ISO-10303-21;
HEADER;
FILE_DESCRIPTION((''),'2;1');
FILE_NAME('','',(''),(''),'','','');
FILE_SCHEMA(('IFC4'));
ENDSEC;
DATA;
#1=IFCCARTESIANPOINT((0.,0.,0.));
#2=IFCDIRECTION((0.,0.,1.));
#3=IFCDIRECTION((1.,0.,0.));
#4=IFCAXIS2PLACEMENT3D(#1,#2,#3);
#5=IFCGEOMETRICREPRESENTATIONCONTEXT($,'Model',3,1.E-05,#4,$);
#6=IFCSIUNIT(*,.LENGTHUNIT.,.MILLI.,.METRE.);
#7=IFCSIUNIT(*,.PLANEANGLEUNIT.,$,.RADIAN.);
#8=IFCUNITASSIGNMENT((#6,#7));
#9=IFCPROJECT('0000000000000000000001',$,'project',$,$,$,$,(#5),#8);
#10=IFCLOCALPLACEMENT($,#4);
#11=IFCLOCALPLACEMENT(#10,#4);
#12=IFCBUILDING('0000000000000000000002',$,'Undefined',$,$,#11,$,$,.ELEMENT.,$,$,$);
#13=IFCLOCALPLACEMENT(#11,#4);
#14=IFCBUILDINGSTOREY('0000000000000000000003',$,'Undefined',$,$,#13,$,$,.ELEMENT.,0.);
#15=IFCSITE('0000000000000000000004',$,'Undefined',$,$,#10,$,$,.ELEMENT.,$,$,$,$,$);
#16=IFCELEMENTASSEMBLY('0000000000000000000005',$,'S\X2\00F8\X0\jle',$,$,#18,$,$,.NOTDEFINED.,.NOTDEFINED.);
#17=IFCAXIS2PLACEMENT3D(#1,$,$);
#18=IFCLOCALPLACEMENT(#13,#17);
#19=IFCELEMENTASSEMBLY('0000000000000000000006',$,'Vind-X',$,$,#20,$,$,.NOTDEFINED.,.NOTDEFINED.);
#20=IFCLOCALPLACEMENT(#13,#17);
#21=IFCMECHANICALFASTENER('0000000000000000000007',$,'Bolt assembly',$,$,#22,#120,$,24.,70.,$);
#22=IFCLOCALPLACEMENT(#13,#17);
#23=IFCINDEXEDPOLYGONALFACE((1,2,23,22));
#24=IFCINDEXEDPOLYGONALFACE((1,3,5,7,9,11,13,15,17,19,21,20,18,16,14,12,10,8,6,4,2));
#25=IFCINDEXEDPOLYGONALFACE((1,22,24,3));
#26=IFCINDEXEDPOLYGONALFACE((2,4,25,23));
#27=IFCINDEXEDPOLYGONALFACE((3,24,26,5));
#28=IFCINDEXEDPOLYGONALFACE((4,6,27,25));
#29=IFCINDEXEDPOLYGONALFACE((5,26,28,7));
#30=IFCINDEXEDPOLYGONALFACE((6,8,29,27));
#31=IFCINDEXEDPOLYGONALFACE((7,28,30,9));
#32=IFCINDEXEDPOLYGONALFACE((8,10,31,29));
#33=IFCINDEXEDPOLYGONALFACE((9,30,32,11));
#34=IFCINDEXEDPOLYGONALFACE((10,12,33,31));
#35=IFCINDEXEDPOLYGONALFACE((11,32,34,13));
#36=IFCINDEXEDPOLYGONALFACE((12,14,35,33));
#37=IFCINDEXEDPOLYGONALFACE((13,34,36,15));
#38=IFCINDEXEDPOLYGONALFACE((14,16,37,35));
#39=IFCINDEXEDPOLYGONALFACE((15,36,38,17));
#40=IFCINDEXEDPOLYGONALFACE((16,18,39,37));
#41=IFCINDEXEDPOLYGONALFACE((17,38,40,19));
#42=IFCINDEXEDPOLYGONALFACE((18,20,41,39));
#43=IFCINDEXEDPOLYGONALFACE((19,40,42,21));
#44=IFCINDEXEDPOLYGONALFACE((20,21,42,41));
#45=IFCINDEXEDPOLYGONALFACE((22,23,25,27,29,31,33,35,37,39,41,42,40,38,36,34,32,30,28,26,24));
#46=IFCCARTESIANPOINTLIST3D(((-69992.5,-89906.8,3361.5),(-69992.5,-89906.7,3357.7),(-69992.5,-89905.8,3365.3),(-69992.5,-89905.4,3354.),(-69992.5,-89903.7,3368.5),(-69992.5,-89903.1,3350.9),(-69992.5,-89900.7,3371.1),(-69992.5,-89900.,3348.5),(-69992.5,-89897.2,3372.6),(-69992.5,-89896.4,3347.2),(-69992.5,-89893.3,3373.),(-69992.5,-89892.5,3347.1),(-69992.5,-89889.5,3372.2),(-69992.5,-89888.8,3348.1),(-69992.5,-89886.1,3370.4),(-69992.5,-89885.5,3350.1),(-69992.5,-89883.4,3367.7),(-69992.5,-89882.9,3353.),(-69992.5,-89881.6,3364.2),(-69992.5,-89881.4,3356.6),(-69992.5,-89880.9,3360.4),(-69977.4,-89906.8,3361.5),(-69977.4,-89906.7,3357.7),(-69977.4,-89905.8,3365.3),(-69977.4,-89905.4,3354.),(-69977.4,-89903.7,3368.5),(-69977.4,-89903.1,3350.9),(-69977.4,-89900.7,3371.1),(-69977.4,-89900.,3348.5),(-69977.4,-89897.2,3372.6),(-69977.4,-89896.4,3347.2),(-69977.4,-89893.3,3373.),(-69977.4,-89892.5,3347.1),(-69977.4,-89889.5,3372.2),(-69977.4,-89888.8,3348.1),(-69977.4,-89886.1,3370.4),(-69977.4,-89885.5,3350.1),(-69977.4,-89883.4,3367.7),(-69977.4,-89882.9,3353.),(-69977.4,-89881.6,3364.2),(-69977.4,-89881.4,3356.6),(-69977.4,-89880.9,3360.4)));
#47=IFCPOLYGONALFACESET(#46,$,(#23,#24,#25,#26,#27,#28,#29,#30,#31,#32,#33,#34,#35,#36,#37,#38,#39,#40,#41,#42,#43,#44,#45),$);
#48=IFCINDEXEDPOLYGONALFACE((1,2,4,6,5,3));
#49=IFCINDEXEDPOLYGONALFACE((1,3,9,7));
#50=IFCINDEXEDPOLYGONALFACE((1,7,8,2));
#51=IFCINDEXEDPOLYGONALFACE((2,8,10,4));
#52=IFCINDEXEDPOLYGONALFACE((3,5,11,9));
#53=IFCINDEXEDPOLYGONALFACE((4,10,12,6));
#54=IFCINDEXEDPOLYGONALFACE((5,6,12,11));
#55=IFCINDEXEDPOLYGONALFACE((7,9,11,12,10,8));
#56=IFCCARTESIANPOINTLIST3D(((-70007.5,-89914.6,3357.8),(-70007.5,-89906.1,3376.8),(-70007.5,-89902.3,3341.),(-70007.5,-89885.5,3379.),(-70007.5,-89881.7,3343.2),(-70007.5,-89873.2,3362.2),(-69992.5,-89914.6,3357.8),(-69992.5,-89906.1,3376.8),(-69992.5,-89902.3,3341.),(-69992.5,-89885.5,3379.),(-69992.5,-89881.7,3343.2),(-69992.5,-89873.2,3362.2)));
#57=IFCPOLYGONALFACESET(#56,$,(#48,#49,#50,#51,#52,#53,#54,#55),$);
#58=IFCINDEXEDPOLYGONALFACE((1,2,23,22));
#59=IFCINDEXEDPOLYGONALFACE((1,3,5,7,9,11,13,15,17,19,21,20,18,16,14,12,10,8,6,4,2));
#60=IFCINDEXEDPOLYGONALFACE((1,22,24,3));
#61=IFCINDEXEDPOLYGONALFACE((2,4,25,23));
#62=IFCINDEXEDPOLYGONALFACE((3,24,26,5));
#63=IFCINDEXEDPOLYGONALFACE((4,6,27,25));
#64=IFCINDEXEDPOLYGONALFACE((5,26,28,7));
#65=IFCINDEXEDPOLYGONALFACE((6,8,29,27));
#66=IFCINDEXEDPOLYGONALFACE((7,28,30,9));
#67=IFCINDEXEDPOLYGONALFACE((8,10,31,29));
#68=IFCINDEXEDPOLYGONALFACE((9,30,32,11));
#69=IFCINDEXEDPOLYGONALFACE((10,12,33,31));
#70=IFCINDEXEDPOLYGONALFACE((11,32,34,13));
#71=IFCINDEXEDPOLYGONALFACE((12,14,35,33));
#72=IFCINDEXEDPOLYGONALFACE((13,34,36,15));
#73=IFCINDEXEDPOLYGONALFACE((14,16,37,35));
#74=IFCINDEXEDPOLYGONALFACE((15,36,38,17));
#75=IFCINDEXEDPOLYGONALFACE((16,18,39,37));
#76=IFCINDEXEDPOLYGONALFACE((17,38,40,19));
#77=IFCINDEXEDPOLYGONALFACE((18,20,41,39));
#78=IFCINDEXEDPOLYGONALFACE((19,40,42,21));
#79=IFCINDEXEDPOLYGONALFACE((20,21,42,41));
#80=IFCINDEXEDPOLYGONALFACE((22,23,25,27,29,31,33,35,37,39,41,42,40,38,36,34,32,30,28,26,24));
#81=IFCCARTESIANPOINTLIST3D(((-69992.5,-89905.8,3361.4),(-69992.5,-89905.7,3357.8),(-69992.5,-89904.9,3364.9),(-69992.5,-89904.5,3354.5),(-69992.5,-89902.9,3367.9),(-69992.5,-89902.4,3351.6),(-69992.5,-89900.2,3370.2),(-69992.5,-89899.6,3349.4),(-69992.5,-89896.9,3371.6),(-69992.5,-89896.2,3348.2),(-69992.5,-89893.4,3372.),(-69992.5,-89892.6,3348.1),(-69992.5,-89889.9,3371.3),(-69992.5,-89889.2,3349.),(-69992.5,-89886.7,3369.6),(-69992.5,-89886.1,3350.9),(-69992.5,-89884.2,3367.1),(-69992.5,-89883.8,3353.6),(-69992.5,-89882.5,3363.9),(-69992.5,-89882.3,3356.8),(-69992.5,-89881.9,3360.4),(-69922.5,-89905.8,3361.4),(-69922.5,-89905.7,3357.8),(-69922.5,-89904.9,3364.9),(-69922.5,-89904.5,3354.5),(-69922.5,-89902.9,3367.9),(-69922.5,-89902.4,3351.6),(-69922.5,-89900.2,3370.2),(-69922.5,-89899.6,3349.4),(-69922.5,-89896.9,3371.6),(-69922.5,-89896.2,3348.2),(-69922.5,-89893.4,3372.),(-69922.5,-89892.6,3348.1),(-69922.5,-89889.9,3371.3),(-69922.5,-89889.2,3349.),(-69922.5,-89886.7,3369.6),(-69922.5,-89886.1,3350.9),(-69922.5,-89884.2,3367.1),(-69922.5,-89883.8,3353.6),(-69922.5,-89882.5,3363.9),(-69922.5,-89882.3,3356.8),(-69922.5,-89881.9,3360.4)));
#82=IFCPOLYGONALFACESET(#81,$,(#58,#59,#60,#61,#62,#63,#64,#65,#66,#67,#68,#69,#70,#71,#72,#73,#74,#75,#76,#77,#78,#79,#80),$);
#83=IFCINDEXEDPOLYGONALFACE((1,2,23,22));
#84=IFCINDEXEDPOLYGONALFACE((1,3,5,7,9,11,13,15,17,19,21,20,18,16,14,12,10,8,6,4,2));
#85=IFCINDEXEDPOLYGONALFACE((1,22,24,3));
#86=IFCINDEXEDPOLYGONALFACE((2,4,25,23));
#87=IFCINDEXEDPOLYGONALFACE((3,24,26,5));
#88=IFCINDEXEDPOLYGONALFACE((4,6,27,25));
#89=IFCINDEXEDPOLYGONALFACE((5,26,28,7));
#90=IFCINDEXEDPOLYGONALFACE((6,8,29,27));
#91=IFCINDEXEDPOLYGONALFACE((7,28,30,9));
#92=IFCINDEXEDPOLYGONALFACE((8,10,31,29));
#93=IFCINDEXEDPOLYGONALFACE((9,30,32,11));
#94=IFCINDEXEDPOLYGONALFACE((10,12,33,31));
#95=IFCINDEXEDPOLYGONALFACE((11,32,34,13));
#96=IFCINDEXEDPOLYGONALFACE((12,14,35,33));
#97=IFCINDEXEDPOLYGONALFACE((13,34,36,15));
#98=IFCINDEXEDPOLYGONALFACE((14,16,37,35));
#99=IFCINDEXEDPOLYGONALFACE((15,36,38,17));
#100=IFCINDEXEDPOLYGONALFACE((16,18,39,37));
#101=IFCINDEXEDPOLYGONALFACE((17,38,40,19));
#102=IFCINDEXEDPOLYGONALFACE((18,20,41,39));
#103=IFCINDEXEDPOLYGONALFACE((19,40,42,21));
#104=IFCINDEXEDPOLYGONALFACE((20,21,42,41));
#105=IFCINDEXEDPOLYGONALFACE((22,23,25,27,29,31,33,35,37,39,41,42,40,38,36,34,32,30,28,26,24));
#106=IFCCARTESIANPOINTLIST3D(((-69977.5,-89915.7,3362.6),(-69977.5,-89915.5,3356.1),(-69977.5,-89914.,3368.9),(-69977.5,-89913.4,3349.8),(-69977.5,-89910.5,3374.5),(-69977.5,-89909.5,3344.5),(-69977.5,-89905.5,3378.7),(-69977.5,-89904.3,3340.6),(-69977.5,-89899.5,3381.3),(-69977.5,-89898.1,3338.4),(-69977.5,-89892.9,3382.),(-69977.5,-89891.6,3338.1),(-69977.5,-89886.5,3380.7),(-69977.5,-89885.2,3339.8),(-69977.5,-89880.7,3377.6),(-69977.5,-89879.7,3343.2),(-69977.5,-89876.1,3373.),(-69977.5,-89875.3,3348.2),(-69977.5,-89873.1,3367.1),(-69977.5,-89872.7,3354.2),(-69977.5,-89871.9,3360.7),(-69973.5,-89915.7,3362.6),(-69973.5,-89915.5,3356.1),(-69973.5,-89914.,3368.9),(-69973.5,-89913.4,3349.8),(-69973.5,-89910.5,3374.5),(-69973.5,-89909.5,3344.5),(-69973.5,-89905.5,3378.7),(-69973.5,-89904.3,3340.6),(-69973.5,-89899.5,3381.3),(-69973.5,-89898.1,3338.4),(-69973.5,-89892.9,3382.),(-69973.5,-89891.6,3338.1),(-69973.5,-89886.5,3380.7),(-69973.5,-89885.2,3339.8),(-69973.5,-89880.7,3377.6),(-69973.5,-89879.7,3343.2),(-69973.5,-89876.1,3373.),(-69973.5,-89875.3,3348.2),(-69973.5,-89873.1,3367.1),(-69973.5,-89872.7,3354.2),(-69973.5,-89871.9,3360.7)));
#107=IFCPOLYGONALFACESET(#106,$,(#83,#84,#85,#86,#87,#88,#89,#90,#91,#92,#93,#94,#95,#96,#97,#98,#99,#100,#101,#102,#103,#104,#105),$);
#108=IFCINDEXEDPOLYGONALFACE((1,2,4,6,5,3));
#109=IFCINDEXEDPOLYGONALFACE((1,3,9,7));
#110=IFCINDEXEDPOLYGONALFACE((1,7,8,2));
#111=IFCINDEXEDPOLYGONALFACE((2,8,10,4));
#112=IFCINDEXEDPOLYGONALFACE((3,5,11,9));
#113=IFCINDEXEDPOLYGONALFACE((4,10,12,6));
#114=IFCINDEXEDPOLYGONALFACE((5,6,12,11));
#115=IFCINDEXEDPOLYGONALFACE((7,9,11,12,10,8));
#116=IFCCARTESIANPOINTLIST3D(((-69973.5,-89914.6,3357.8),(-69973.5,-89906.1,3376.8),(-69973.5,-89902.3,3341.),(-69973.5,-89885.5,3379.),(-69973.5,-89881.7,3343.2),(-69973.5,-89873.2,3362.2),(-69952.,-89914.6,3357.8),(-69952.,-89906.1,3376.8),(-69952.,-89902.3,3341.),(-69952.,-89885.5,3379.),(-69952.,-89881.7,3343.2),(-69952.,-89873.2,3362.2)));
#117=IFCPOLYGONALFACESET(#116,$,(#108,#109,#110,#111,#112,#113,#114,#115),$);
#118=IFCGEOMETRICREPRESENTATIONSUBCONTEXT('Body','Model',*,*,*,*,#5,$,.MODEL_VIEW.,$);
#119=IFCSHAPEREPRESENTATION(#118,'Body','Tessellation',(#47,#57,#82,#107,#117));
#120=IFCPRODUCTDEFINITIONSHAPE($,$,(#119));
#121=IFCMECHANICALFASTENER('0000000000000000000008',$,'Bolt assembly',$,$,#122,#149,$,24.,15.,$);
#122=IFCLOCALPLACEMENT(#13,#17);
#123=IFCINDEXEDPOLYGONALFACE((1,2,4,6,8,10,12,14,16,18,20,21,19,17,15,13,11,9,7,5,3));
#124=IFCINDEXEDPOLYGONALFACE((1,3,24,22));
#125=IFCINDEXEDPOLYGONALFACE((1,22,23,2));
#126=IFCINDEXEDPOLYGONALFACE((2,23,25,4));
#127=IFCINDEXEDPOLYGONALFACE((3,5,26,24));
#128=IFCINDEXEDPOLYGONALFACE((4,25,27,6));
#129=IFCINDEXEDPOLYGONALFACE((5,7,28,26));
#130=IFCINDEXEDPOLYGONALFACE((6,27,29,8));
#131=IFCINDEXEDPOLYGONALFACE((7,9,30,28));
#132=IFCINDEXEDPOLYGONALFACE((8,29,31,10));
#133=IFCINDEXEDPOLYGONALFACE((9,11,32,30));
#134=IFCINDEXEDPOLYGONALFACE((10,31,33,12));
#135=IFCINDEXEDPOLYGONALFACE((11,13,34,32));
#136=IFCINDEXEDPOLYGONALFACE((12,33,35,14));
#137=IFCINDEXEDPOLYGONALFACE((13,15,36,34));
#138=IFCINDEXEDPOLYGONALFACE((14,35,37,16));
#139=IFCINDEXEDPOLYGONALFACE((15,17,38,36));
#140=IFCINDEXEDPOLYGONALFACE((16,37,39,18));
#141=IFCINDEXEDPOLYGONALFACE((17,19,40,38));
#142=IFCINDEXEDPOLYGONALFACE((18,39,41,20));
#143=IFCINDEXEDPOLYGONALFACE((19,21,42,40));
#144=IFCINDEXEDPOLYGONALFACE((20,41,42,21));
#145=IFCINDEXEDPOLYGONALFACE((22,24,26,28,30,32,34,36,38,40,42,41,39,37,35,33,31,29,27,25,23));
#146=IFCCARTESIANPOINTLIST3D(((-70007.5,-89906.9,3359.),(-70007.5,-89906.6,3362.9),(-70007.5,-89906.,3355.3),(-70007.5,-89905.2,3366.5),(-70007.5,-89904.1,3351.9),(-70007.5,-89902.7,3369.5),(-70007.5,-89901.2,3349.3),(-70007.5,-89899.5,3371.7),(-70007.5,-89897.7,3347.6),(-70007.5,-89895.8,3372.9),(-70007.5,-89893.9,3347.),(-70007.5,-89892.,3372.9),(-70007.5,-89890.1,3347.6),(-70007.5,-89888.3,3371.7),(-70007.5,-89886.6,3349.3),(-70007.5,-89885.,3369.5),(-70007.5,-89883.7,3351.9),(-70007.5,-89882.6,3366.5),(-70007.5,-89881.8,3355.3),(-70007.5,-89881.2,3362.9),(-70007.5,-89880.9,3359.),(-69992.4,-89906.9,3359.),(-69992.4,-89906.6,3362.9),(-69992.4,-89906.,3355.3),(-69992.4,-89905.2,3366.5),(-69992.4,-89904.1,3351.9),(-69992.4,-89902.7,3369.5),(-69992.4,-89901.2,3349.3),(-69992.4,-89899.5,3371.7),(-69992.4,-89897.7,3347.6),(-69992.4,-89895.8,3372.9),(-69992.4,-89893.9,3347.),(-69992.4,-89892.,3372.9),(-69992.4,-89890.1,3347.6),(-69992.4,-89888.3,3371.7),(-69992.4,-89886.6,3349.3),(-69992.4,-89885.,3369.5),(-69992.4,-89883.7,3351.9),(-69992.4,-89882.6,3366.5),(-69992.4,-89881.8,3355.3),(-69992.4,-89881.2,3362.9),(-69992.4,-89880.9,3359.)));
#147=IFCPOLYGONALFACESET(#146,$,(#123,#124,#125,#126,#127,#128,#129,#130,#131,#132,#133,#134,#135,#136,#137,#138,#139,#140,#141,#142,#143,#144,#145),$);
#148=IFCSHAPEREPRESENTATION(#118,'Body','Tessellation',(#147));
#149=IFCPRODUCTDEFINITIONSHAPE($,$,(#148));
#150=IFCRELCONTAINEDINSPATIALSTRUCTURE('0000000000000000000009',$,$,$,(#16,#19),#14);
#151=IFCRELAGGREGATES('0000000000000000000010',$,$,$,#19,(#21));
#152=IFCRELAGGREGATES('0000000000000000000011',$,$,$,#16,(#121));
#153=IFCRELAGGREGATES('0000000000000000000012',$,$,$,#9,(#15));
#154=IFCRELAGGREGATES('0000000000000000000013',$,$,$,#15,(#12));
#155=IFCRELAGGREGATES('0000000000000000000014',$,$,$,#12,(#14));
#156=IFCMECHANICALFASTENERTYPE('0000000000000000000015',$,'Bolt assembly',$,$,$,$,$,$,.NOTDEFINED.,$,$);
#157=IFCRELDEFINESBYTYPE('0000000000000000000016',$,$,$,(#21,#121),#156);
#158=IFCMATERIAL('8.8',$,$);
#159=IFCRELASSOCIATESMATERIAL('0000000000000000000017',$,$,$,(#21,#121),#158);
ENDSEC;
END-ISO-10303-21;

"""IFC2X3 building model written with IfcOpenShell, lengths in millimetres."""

from ifc_helpers import new_model, si_unit, frame, origin_with_axes, origin_2d_with_axis, place, context, subcontext, project, spatial, polyline, circle, outline, extrude, source, transform, mapped, material, type_object, element, aggregate, save


model = new_model("IFC2X3")

# Units and contexts
model_context = context("Model", 3, precision=1e-05, world=origin_with_axes())
body_context = subcontext(model_context, "Body", "Model", "MODEL_VIEW")
ifc_project = project(units=[si_unit("LENGTHUNIT", "METRE", prefix="MILLI"), si_unit("PLANEANGLEUNIT", "RADIAN")], contexts=[model_context])

# Site, building, storey
site_placement = place(None, origin_with_axes())
site = spatial("IfcSite", under=ifc_project, at=site_placement, Name="Undefined", CompositionType="ELEMENT")
building_placement = place(site_placement, origin_with_axes())
building = spatial("IfcBuilding", under=site, at=building_placement, Name="Undefined", CompositionType="ELEMENT")
storey_placement = place(building_placement, origin_with_axes())
storey = spatial("IfcBuildingStorey", under=building, at=storey_placement, Name="Undefined", CompositionType="ELEMENT", Elevation=0.0)

# Element assembly
assembly_1_placement = place(storey_placement, origin_with_axes())
assembly_1 = element("IfcElementAssembly", 1, at=assembly_1_placement, inside=storey, Name="Søjle", AssemblyPlace="NOTDEFINED", PredefinedType="NOTDEFINED")

# Element assembly
assembly_2_placement = place(storey_placement, origin_with_axes())
assembly_2 = element("IfcElementAssembly", 2, at=assembly_2_placement, inside=storey, Name="Vind-X", AssemblyPlace="NOTDEFINED", PredefinedType="NOTDEFINED")

# Mechanical fasteners
ifc_material_1 = material(Name="8.8")
mechanical_fastener_type = type_object("IfcMechanicalFastenerType", Name="Bolt assembly")
shared_shape_1 = source(origin_with_axes(), body_context, "Body", "SweptSolid", [
    extrude(circle(Radius=13.0, at=origin_2d_with_axis()), frame((0.0, 0.0, 0.0), z_axis=(0.0, 1.0, 0.0), x_axis=(1.0, 0.0, 0.0)), (0.0, 0.0, 1.0), 15.1),
    extrude(outline(polyline([(18.0, -10.4), (18.0, 10.4), (0.0, 20.8), (-18.0, 10.4), (-18.0, -10.4), (0.0, -20.8), (18.0, -10.4)])), frame((0.0, -15.0, 0.0), z_axis=(0.0, 1.0, 0.0), x_axis=(1.0, 0.0, 0.0)), (0.0, 0.0, 1.0), 15.0),
    extrude(circle(Radius=12.0, at=origin_2d_with_axis()), frame((0.0, 0.0, 0.0), z_axis=(0.0, 1.0, 0.0), x_axis=(1.0, 0.0, 0.0)), (0.0, 0.0, 1.0), 70.0),
    extrude(circle(Radius=22.0, at=origin_2d_with_axis()), frame((0.0, 15.0, 0.0), z_axis=(0.0, 1.0, 0.0), x_axis=(1.0, 0.0, 0.0)), (0.0, 0.0, 1.0), 4.0),
    extrude(outline(polyline([(18.0, -10.4), (18.0, 10.4), (0.0, 20.8), (-18.0, 10.4), (-18.0, -10.4), (0.0, -20.8), (18.0, -10.4)])), frame((0.0, 19.0, 0.0), z_axis=(0.0, 1.0, 0.0), x_axis=(1.0, 0.0, 0.0)), (0.0, 0.0, 1.0), 21.5),
])
mechanical_fastener_1_placement = place(assembly_2_placement, frame((-69992.5, -89893.9, 3360.0), z_axis=(0.0, 0.588616, -0.808413), x_axis=(0.0, 0.808413, 0.588616)))
mechanical_fastener_1 = element("IfcMechanicalFastener", 3, at=mechanical_fastener_1_placement, type_object=mechanical_fastener_type, material=ifc_material_1, Name="Bolt assembly", NominalDiameter=24.0, NominalLength=70.0, context=body_context, shape_type="MappedRepresentation", body=[
    mapped(shared_shape_1, transform((0.0, 0.0, 0.0))),
])
aggregate(assembly_2, [mechanical_fastener_1])
shared_shape_2 = source(origin_with_axes(), body_context, "Body", "SweptSolid", [
    extrude(circle(Radius=13.0, at=origin_2d_with_axis()), frame((0.0, -7.5, 0.0), z_axis=(0.0, 1.0, 0.0), x_axis=(1.0, 0.0, 0.0)), (0.0, 0.0, 1.0), 15.1),
])
mechanical_fastener_2_placement = place(assembly_1_placement, frame((-70000.0, -89893.9, 3360.0), z_axis=(0.0, -1.0, 0.0), x_axis=(0.0, 0.0, -1.0)))
mechanical_fastener_2 = element("IfcMechanicalFastener", 4, at=mechanical_fastener_2_placement, type_object=mechanical_fastener_type, material=ifc_material_1, Name="Bolt assembly", NominalDiameter=24.0, NominalLength=15.0, context=body_context, shape_type="MappedRepresentation", body=[
    mapped(shared_shape_2, transform((0.0, 0.0, 0.0))),
])
aggregate(assembly_1, [mechanical_fastener_2])

save(model, "model.ifc")
